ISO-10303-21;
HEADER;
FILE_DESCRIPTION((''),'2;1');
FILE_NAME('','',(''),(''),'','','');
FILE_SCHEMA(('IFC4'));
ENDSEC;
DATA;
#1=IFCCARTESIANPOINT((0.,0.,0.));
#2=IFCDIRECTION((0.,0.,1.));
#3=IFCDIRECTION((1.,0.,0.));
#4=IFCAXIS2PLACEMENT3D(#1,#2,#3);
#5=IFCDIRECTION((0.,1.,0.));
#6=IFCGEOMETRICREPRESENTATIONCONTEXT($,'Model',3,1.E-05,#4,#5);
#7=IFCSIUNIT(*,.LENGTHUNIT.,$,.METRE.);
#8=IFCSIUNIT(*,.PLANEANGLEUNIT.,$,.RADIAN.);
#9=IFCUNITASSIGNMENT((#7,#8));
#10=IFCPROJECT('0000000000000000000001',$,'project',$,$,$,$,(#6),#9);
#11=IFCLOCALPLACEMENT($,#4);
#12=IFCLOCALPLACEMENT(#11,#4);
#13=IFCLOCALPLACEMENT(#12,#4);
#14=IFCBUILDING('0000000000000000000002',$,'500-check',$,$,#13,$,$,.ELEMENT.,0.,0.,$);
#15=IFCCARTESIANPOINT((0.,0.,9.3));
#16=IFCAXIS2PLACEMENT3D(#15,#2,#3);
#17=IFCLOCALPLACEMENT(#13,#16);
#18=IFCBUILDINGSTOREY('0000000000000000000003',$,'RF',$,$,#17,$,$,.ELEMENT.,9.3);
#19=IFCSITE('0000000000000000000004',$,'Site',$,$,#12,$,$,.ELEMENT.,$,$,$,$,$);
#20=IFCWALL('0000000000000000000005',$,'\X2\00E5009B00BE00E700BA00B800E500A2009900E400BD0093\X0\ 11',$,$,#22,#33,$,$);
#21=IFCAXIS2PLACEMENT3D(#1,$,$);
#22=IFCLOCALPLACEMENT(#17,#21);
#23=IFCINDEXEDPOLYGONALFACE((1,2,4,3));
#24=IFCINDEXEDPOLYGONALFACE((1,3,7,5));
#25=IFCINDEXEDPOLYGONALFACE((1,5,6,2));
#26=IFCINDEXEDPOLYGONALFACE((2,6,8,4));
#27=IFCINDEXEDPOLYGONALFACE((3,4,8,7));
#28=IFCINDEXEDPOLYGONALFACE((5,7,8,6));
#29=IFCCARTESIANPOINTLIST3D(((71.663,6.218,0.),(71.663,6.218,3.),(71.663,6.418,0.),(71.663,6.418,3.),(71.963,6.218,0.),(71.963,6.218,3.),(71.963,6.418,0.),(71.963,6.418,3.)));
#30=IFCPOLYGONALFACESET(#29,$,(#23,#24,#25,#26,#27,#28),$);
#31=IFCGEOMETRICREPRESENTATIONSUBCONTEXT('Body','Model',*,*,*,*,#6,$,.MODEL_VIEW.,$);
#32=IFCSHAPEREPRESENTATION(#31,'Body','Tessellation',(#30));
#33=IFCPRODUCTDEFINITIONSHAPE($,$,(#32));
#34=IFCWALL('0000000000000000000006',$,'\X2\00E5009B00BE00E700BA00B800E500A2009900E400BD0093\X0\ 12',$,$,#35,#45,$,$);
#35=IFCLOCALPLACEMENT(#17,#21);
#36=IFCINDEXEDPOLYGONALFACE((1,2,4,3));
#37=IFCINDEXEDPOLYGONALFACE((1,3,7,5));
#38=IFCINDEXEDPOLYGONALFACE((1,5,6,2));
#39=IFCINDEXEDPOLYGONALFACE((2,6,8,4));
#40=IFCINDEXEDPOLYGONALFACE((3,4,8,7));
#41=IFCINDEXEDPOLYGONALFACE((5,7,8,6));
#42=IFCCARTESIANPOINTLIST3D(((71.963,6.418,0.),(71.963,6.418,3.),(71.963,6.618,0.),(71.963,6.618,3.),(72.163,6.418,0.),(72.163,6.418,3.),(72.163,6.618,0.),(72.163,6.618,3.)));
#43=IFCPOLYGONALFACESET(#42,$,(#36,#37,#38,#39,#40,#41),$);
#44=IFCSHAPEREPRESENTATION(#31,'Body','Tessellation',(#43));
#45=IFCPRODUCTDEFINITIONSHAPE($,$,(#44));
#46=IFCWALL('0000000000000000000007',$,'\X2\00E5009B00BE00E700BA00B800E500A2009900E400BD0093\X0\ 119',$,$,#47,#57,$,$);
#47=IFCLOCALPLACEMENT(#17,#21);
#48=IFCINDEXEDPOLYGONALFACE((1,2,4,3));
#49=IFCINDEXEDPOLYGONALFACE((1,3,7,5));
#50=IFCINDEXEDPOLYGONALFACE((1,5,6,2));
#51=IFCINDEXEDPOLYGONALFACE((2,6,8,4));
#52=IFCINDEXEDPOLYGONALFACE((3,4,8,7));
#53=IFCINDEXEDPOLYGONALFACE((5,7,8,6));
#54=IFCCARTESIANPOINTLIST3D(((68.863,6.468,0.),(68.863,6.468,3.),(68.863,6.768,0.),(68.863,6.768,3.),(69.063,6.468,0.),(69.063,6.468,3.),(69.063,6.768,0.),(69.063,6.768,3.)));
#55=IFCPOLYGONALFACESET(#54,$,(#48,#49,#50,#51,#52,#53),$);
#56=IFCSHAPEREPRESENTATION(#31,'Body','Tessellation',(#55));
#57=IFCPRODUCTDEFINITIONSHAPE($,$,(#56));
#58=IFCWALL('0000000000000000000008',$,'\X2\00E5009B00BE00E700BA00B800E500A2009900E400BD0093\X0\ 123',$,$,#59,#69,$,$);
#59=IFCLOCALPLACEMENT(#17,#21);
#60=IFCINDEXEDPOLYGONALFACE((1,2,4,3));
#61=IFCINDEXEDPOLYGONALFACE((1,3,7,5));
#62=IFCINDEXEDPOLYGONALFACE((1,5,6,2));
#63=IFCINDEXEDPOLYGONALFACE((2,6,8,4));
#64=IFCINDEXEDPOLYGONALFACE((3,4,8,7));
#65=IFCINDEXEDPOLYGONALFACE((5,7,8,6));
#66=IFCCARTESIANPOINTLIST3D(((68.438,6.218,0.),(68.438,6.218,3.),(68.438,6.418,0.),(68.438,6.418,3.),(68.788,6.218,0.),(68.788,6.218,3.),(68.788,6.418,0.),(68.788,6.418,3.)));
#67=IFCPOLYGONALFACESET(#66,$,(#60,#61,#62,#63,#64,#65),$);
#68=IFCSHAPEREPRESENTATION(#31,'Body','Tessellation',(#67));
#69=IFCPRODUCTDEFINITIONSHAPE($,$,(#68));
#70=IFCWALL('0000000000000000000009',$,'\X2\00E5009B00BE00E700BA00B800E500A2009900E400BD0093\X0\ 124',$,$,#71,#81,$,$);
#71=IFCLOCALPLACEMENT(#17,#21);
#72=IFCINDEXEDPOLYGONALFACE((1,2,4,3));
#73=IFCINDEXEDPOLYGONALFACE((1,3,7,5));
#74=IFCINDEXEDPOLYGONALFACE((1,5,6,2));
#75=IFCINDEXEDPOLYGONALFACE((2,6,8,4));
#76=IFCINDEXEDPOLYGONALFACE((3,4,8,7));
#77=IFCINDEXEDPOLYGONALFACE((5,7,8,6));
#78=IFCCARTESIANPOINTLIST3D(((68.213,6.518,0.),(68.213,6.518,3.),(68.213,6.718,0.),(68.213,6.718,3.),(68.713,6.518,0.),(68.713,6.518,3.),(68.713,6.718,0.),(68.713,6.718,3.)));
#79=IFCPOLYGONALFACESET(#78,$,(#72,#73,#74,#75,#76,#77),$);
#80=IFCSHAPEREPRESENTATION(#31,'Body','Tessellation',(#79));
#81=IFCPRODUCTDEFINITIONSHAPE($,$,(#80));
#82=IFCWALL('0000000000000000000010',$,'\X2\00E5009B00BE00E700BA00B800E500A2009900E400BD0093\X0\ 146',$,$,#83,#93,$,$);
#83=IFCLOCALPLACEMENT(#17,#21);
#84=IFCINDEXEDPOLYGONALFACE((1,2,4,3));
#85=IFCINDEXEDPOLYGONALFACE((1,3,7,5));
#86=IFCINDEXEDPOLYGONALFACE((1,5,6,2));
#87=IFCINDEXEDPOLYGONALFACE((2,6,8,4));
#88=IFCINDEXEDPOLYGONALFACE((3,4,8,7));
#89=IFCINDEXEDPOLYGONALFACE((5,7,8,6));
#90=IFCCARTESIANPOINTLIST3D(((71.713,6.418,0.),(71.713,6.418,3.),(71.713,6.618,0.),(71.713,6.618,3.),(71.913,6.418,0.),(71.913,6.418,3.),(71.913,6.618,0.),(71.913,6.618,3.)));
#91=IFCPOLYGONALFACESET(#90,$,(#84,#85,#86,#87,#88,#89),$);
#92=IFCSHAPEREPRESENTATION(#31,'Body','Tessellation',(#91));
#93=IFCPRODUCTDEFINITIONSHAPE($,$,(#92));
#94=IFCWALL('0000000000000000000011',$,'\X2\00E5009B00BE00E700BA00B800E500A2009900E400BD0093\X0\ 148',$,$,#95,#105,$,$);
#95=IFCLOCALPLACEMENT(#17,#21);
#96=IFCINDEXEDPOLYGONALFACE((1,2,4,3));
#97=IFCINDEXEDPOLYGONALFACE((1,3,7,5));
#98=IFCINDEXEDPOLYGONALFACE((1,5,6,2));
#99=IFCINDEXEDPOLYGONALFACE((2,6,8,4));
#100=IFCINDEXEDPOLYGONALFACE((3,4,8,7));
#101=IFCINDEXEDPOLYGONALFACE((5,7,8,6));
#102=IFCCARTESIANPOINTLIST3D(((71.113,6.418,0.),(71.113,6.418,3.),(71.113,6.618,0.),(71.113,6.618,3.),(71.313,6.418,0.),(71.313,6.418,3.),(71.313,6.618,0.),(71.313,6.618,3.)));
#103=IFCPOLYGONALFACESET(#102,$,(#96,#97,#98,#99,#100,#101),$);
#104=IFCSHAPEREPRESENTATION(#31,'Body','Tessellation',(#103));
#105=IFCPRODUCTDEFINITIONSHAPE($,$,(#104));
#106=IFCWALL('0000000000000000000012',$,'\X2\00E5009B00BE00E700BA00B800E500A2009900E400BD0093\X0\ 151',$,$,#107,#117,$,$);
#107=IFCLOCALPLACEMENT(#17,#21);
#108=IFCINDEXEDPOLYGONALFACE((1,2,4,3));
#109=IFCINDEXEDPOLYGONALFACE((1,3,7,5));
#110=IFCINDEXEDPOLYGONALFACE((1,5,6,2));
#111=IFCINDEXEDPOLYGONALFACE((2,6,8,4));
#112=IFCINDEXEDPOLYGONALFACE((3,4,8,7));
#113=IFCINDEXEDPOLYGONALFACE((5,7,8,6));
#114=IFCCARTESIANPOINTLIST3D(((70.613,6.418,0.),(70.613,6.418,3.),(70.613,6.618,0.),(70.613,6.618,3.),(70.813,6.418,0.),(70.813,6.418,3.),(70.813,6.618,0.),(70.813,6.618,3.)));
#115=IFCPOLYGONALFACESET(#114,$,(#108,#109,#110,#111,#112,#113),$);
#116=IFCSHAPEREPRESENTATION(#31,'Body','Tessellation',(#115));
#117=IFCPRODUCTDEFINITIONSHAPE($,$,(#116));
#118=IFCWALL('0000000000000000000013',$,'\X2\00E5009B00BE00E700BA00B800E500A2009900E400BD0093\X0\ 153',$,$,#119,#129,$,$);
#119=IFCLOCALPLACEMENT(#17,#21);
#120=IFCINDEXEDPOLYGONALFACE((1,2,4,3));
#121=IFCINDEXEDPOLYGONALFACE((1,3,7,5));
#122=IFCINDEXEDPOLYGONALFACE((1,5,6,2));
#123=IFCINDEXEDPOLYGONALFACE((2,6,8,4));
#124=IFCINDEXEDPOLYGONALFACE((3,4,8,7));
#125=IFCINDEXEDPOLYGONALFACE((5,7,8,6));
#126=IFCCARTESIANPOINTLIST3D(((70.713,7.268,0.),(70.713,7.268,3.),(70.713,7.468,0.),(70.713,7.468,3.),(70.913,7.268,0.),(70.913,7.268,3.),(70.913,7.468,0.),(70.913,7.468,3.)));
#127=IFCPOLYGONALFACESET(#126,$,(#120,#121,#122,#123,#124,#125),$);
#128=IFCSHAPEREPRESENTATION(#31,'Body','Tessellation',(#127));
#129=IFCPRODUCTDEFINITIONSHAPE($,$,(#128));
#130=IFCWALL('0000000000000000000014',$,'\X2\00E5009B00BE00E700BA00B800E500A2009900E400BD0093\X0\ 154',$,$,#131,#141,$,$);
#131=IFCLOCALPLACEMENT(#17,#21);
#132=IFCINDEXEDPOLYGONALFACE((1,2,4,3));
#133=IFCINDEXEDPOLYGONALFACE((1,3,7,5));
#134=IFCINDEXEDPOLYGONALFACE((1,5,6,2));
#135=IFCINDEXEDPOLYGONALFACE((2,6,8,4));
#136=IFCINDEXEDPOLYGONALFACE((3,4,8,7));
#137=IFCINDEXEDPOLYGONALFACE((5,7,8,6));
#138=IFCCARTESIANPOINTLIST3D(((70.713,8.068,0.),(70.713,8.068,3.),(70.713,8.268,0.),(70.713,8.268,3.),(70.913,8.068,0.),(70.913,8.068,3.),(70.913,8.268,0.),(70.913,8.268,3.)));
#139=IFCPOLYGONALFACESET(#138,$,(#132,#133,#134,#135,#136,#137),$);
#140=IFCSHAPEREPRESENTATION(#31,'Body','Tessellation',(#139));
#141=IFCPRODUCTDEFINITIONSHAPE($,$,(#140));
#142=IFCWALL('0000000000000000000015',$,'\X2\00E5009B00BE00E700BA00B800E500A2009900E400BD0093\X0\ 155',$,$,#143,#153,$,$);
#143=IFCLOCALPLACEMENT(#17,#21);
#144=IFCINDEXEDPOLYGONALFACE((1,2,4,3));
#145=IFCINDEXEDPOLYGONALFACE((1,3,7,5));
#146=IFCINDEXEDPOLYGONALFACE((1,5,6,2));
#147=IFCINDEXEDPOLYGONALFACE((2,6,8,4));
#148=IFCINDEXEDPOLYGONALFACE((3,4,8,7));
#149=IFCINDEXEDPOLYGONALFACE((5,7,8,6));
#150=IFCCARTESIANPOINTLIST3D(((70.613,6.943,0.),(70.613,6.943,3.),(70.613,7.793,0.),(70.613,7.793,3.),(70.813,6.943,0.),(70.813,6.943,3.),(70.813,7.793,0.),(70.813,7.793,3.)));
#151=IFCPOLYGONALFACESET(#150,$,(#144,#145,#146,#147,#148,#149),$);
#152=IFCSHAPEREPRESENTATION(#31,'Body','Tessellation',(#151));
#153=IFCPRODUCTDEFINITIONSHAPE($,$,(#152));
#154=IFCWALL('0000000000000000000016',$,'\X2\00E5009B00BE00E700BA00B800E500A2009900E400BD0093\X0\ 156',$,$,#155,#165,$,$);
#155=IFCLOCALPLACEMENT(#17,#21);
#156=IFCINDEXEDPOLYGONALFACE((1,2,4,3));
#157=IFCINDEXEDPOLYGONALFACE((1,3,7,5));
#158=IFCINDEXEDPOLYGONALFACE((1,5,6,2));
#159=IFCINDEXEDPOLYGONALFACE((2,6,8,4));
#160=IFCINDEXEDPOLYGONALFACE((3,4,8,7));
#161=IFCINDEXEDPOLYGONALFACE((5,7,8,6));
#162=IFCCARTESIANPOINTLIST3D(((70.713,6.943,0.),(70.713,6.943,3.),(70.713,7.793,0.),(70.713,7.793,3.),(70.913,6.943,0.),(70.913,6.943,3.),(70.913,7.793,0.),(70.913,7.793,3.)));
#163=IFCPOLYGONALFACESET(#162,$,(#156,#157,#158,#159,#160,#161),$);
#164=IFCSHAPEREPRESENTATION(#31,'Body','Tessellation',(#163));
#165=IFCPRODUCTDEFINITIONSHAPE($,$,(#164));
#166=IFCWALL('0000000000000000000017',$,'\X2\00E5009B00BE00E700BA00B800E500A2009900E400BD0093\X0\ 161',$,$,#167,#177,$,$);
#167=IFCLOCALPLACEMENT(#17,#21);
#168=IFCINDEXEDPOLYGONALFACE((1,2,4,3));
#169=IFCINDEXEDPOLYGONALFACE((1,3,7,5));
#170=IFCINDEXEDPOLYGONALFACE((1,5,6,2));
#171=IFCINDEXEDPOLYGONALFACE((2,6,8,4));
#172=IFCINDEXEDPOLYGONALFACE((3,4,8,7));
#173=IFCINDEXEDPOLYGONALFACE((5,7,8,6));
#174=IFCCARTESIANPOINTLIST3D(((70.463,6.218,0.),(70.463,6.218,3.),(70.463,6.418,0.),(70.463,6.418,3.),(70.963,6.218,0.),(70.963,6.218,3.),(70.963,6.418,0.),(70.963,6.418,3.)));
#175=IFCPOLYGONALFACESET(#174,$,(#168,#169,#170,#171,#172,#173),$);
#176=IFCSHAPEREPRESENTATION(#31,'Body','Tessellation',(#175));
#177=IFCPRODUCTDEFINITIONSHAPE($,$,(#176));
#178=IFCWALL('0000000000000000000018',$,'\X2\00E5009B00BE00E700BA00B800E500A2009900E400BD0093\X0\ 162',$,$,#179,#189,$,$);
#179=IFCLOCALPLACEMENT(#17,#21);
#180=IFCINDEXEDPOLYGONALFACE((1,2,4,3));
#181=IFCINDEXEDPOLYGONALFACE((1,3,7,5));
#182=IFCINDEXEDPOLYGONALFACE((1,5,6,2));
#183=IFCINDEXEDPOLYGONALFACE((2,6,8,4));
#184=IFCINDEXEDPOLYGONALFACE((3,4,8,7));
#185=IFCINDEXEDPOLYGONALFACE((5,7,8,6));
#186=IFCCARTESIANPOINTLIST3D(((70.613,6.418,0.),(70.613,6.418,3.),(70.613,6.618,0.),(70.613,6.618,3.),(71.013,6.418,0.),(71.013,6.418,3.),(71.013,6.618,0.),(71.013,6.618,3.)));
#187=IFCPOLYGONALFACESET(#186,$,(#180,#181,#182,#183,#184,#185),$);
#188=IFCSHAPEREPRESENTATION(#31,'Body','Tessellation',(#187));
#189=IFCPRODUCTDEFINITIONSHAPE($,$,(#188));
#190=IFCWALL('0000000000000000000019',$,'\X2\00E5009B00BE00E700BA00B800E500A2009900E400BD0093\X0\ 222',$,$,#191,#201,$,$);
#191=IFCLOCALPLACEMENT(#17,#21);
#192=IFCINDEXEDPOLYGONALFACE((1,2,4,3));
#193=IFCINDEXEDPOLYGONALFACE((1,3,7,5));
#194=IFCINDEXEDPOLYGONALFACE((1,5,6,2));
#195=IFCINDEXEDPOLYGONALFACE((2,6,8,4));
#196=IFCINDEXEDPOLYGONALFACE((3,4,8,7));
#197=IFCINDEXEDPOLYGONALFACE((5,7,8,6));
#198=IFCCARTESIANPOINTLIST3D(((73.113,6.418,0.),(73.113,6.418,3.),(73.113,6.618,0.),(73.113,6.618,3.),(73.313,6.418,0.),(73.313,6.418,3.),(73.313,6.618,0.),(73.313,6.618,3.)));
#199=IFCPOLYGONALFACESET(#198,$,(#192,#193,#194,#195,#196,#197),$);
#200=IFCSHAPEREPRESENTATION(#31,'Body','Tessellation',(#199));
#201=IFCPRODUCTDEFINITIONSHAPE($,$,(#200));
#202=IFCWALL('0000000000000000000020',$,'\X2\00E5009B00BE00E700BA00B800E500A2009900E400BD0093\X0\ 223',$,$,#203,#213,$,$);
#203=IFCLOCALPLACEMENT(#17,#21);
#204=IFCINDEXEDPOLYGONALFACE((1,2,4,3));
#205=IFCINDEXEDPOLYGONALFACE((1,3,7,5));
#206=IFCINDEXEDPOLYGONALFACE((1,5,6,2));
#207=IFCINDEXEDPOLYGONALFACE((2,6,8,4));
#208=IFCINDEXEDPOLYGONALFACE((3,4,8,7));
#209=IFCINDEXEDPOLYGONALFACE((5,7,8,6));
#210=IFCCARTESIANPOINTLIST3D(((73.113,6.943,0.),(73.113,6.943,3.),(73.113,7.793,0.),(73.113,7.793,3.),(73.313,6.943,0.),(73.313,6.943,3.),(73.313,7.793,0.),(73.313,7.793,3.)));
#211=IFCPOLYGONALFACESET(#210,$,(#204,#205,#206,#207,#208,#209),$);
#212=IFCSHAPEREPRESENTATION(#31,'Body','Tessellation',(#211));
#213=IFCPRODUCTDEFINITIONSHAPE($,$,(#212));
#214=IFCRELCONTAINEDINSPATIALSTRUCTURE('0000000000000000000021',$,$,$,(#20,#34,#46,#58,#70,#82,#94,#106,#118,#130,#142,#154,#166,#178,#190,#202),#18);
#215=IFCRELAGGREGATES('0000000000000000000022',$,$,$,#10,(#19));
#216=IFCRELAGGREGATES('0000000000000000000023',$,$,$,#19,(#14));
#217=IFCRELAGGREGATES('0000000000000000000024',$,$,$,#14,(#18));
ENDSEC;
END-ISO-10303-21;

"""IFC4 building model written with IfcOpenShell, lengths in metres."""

from ifc_helpers import new_model, si_unit, direction, frame, frame_2d, origin_with_axes, place, context, subcontext, project, spatial, rectangle, extrude, element, save


model = new_model("IFC4")

# Units and contexts
model_context = context("Model", 3, precision=1e-05, world=origin_with_axes(), true_north=direction((0.0, 1.0, 0.0)))
body_context = subcontext(model_context, "Body", "Model", "MODEL_VIEW")
ifc_project = project(units=[si_unit("LENGTHUNIT", "METRE"), si_unit("PLANEANGLEUNIT", "RADIAN")], contexts=[model_context])

# Site, building, storey
placement = place(None, origin_with_axes())
site_placement = place(placement, origin_with_axes())
site = spatial("IfcSite", under=ifc_project, at=site_placement, Name="Site", CompositionType="ELEMENT")
building_placement = place(site_placement, origin_with_axes())
building = spatial("IfcBuilding", under=site, at=building_placement, Name="500-check", CompositionType="ELEMENT", ElevationOfRefHeight=0.0, ElevationOfTerrain=0.0)
storey_placement = place(building_placement, frame((0.0, 0.0, 9.3), z_axis=(0.0, 0.0, 1.0), x_axis=(1.0, 0.0, 0.0)))
storey = spatial("IfcBuildingStorey", under=building, at=storey_placement, Name="RF", CompositionType="ELEMENT", Elevation=9.3)

# Walls
wall_1_placement = place(storey_placement, frame((71.813, 6.318, 0.0), z_axis=(0.0, 0.0, 1.0), x_axis=(1.0, 0.0, 0.0)))
element("IfcWall", 1, at=wall_1_placement, inside=storey, Name="å\u009b¾çº¸å¢\u0099ä½\u0093 11", context=body_context, shape_type="SweptSolid", body=[
    extrude(rectangle(XDim=0.3, YDim=0.2, at=frame_2d((0.0, 0.0), x_axis=(1.0, 0.0, 0.0))), frame((0.0, 0.0, 0.0), z_axis=(0.0, 0.0, 1.0)), (0.0, 0.0, 1.0), 3.0),
])
wall_2_placement = place(storey_placement, frame((72.063, 6.518, 0.0), z_axis=(0.0, 0.0, 1.0), x_axis=(1.0, 0.0, 0.0)))
element("IfcWall", 2, at=wall_2_placement, inside=storey, Name="å\u009b¾çº¸å¢\u0099ä½\u0093 12", context=body_context, shape_type="SweptSolid", body=[
    extrude(rectangle(XDim=0.2, YDim=0.2, at=frame_2d((0.0, 0.0), x_axis=(1.0, 0.0, 0.0))), frame((0.0, 0.0, 0.0), z_axis=(0.0, 0.0, 1.0)), (0.0, 0.0, 1.0), 3.0),
])
wall_3_placement = place(storey_placement, frame((68.963, 6.618, 0.0), z_axis=(0.0, 0.0, 1.0), x_axis=(0.0, -1.0, 0.0)))
element("IfcWall", 3, at=wall_3_placement, inside=storey, Name="å\u009b¾çº¸å¢\u0099ä½\u0093 119", context=body_context, shape_type="SweptSolid", body=[
    extrude(rectangle(XDim=0.3, YDim=0.2, at=frame_2d((0.0, 0.0), x_axis=(1.0, 0.0, 0.0))), frame((0.0, 0.0, 0.0), z_axis=(0.0, 0.0, 1.0)), (0.0, 0.0, 1.0), 3.0),
])
wall_4_placement = place(storey_placement, frame((68.613, 6.318, 0.0), z_axis=(0.0, 0.0, 1.0), x_axis=(1.0, 0.0, 0.0)))
element("IfcWall", 4, at=wall_4_placement, inside=storey, Name="å\u009b¾çº¸å¢\u0099ä½\u0093 123", context=body_context, shape_type="SweptSolid", body=[
    extrude(rectangle(XDim=0.35, YDim=0.2, at=frame_2d((0.0, 0.0), x_axis=(1.0, 0.0, 0.0))), frame((0.0, 0.0, 0.0), z_axis=(0.0, 0.0, 1.0)), (0.0, 0.0, 1.0), 3.0),
])
wall_5_placement = place(storey_placement, frame((68.463, 6.618, 0.0), z_axis=(0.0, 0.0, 1.0), x_axis=(1.0, 0.0, 0.0)))
element("IfcWall", 5, at=wall_5_placement, inside=storey, Name="å\u009b¾çº¸å¢\u0099ä½\u0093 124", context=body_context, shape_type="SweptSolid", body=[
    extrude(rectangle(XDim=0.5, YDim=0.2, at=frame_2d((0.0, 0.0), x_axis=(1.0, 0.0, 0.0))), frame((0.0, 0.0, 0.0), z_axis=(0.0, 0.0, 1.0)), (0.0, 0.0, 1.0), 3.0),
])
for number, where, z_axis, x_axis, name in (
    (6, (71.813, 6.518, 0.0), (0.0, 0.0, 1.0), (1.0, 0.0, 0.0), "å\u009b¾çº¸å¢\u0099ä½\u0093 146"),
    (7, (71.213, 6.518, 0.0), (0.0, 0.0, 1.0), (0.0, -1.0, 0.0), "å\u009b¾çº¸å¢\u0099ä½\u0093 148"),
    (8, (70.713, 6.518, 0.0), (0.0, 0.0, 1.0), (0.0, -1.0, 0.0), "å\u009b¾çº¸å¢\u0099ä½\u0093 151"),
    (9, (70.813, 7.368, 0.0), (0.0, 0.0, 1.0), (-1.0, 0.0, 0.0), "å\u009b¾çº¸å¢\u0099ä½\u0093 153"),
    (10, (70.813, 8.168, 0.0), (0.0, 0.0, 1.0), (-1.0, 0.0, 0.0), "å\u009b¾çº¸å¢\u0099ä½\u0093 154"),
):
    element("IfcWall", number, at=place(storey_placement, frame(where, z_axis=z_axis, x_axis=x_axis)), inside=storey, Name=name, context=body_context, shape_type="SweptSolid", body=[
        extrude(rectangle(XDim=0.2, YDim=0.2, at=frame_2d((0.0, 0.0), x_axis=(1.0, 0.0, 0.0))), frame((0.0, 0.0, 0.0), z_axis=(0.0, 0.0, 1.0)), (0.0, 0.0, 1.0), 3.0),
    ])
for number, where, z_axis, x_axis, name in (
    (11, (70.713, 7.368, 0.0), (0.0, 0.0, 1.0), (0.0, -1.0, 0.0), "å\u009b¾çº¸å¢\u0099ä½\u0093 155"),
    (12, (70.813, 7.368, 0.0), (0.0, 0.0, 1.0), (0.0, -1.0, 0.0), "å\u009b¾çº¸å¢\u0099ä½\u0093 156"),
):
    element("IfcWall", number, at=place(storey_placement, frame(where, z_axis=z_axis, x_axis=x_axis)), inside=storey, Name=name, context=body_context, shape_type="SweptSolid", body=[
        extrude(rectangle(XDim=0.85, YDim=0.2, at=frame_2d((0.0, 0.0), x_axis=(1.0, 0.0, 0.0))), frame((0.0, 0.0, 0.0), z_axis=(0.0, 0.0, 1.0)), (0.0, 0.0, 1.0), 3.0),
    ])
wall_6_placement = place(storey_placement, frame((70.713, 6.318, 0.0), z_axis=(0.0, 0.0, 1.0), x_axis=(1.0, 0.0, 0.0)))
element("IfcWall", 13, at=wall_6_placement, inside=storey, Name="å\u009b¾çº¸å¢\u0099ä½\u0093 161", context=body_context, shape_type="SweptSolid", body=[
    extrude(rectangle(XDim=0.5, YDim=0.2, at=frame_2d((0.0, 0.0), x_axis=(1.0, 0.0, 0.0))), frame((0.0, 0.0, 0.0), z_axis=(0.0, 0.0, 1.0)), (0.0, 0.0, 1.0), 3.0),
])
wall_7_placement = place(storey_placement, frame((70.813, 6.518, 0.0), z_axis=(0.0, 0.0, 1.0), x_axis=(1.0, 0.0, 0.0)))
element("IfcWall", 14, at=wall_7_placement, inside=storey, Name="å\u009b¾çº¸å¢\u0099ä½\u0093 162", context=body_context, shape_type="SweptSolid", body=[
    extrude(rectangle(XDim=0.4, YDim=0.2, at=frame_2d((0.0, 0.0), x_axis=(1.0, 0.0, 0.0))), frame((0.0, 0.0, 0.0), z_axis=(0.0, 0.0, 1.0)), (0.0, 0.0, 1.0), 3.0),
])
wall_8_placement = place(storey_placement, frame((73.213, 6.518, 0.0), z_axis=(0.0, 0.0, 1.0), x_axis=(0.0, -1.0, 0.0)))
element("IfcWall", 15, at=wall_8_placement, inside=storey, Name="å\u009b¾çº¸å¢\u0099ä½\u0093 222", context=body_context, shape_type="SweptSolid", body=[
    extrude(rectangle(XDim=0.2, YDim=0.2, at=frame_2d((0.0, 0.0), x_axis=(1.0, 0.0, 0.0))), frame((0.0, 0.0, 0.0), z_axis=(0.0, 0.0, 1.0)), (0.0, 0.0, 1.0), 3.0),
])
wall_9_placement = place(storey_placement, frame((73.213, 7.368, 0.0), z_axis=(0.0, 0.0, 1.0), x_axis=(0.0, -1.0, 0.0)))
element("IfcWall", 16, at=wall_9_placement, inside=storey, Name="å\u009b¾çº¸å¢\u0099ä½\u0093 223", context=body_context, shape_type="SweptSolid", body=[
    extrude(rectangle(XDim=0.85, YDim=0.2, at=frame_2d((0.0, 0.0), x_axis=(1.0, 0.0, 0.0))), frame((0.0, 0.0, 0.0), z_axis=(0.0, 0.0, 1.0)), (0.0, 0.0, 1.0), 3.0),
])

save(model, "model.ifc")
